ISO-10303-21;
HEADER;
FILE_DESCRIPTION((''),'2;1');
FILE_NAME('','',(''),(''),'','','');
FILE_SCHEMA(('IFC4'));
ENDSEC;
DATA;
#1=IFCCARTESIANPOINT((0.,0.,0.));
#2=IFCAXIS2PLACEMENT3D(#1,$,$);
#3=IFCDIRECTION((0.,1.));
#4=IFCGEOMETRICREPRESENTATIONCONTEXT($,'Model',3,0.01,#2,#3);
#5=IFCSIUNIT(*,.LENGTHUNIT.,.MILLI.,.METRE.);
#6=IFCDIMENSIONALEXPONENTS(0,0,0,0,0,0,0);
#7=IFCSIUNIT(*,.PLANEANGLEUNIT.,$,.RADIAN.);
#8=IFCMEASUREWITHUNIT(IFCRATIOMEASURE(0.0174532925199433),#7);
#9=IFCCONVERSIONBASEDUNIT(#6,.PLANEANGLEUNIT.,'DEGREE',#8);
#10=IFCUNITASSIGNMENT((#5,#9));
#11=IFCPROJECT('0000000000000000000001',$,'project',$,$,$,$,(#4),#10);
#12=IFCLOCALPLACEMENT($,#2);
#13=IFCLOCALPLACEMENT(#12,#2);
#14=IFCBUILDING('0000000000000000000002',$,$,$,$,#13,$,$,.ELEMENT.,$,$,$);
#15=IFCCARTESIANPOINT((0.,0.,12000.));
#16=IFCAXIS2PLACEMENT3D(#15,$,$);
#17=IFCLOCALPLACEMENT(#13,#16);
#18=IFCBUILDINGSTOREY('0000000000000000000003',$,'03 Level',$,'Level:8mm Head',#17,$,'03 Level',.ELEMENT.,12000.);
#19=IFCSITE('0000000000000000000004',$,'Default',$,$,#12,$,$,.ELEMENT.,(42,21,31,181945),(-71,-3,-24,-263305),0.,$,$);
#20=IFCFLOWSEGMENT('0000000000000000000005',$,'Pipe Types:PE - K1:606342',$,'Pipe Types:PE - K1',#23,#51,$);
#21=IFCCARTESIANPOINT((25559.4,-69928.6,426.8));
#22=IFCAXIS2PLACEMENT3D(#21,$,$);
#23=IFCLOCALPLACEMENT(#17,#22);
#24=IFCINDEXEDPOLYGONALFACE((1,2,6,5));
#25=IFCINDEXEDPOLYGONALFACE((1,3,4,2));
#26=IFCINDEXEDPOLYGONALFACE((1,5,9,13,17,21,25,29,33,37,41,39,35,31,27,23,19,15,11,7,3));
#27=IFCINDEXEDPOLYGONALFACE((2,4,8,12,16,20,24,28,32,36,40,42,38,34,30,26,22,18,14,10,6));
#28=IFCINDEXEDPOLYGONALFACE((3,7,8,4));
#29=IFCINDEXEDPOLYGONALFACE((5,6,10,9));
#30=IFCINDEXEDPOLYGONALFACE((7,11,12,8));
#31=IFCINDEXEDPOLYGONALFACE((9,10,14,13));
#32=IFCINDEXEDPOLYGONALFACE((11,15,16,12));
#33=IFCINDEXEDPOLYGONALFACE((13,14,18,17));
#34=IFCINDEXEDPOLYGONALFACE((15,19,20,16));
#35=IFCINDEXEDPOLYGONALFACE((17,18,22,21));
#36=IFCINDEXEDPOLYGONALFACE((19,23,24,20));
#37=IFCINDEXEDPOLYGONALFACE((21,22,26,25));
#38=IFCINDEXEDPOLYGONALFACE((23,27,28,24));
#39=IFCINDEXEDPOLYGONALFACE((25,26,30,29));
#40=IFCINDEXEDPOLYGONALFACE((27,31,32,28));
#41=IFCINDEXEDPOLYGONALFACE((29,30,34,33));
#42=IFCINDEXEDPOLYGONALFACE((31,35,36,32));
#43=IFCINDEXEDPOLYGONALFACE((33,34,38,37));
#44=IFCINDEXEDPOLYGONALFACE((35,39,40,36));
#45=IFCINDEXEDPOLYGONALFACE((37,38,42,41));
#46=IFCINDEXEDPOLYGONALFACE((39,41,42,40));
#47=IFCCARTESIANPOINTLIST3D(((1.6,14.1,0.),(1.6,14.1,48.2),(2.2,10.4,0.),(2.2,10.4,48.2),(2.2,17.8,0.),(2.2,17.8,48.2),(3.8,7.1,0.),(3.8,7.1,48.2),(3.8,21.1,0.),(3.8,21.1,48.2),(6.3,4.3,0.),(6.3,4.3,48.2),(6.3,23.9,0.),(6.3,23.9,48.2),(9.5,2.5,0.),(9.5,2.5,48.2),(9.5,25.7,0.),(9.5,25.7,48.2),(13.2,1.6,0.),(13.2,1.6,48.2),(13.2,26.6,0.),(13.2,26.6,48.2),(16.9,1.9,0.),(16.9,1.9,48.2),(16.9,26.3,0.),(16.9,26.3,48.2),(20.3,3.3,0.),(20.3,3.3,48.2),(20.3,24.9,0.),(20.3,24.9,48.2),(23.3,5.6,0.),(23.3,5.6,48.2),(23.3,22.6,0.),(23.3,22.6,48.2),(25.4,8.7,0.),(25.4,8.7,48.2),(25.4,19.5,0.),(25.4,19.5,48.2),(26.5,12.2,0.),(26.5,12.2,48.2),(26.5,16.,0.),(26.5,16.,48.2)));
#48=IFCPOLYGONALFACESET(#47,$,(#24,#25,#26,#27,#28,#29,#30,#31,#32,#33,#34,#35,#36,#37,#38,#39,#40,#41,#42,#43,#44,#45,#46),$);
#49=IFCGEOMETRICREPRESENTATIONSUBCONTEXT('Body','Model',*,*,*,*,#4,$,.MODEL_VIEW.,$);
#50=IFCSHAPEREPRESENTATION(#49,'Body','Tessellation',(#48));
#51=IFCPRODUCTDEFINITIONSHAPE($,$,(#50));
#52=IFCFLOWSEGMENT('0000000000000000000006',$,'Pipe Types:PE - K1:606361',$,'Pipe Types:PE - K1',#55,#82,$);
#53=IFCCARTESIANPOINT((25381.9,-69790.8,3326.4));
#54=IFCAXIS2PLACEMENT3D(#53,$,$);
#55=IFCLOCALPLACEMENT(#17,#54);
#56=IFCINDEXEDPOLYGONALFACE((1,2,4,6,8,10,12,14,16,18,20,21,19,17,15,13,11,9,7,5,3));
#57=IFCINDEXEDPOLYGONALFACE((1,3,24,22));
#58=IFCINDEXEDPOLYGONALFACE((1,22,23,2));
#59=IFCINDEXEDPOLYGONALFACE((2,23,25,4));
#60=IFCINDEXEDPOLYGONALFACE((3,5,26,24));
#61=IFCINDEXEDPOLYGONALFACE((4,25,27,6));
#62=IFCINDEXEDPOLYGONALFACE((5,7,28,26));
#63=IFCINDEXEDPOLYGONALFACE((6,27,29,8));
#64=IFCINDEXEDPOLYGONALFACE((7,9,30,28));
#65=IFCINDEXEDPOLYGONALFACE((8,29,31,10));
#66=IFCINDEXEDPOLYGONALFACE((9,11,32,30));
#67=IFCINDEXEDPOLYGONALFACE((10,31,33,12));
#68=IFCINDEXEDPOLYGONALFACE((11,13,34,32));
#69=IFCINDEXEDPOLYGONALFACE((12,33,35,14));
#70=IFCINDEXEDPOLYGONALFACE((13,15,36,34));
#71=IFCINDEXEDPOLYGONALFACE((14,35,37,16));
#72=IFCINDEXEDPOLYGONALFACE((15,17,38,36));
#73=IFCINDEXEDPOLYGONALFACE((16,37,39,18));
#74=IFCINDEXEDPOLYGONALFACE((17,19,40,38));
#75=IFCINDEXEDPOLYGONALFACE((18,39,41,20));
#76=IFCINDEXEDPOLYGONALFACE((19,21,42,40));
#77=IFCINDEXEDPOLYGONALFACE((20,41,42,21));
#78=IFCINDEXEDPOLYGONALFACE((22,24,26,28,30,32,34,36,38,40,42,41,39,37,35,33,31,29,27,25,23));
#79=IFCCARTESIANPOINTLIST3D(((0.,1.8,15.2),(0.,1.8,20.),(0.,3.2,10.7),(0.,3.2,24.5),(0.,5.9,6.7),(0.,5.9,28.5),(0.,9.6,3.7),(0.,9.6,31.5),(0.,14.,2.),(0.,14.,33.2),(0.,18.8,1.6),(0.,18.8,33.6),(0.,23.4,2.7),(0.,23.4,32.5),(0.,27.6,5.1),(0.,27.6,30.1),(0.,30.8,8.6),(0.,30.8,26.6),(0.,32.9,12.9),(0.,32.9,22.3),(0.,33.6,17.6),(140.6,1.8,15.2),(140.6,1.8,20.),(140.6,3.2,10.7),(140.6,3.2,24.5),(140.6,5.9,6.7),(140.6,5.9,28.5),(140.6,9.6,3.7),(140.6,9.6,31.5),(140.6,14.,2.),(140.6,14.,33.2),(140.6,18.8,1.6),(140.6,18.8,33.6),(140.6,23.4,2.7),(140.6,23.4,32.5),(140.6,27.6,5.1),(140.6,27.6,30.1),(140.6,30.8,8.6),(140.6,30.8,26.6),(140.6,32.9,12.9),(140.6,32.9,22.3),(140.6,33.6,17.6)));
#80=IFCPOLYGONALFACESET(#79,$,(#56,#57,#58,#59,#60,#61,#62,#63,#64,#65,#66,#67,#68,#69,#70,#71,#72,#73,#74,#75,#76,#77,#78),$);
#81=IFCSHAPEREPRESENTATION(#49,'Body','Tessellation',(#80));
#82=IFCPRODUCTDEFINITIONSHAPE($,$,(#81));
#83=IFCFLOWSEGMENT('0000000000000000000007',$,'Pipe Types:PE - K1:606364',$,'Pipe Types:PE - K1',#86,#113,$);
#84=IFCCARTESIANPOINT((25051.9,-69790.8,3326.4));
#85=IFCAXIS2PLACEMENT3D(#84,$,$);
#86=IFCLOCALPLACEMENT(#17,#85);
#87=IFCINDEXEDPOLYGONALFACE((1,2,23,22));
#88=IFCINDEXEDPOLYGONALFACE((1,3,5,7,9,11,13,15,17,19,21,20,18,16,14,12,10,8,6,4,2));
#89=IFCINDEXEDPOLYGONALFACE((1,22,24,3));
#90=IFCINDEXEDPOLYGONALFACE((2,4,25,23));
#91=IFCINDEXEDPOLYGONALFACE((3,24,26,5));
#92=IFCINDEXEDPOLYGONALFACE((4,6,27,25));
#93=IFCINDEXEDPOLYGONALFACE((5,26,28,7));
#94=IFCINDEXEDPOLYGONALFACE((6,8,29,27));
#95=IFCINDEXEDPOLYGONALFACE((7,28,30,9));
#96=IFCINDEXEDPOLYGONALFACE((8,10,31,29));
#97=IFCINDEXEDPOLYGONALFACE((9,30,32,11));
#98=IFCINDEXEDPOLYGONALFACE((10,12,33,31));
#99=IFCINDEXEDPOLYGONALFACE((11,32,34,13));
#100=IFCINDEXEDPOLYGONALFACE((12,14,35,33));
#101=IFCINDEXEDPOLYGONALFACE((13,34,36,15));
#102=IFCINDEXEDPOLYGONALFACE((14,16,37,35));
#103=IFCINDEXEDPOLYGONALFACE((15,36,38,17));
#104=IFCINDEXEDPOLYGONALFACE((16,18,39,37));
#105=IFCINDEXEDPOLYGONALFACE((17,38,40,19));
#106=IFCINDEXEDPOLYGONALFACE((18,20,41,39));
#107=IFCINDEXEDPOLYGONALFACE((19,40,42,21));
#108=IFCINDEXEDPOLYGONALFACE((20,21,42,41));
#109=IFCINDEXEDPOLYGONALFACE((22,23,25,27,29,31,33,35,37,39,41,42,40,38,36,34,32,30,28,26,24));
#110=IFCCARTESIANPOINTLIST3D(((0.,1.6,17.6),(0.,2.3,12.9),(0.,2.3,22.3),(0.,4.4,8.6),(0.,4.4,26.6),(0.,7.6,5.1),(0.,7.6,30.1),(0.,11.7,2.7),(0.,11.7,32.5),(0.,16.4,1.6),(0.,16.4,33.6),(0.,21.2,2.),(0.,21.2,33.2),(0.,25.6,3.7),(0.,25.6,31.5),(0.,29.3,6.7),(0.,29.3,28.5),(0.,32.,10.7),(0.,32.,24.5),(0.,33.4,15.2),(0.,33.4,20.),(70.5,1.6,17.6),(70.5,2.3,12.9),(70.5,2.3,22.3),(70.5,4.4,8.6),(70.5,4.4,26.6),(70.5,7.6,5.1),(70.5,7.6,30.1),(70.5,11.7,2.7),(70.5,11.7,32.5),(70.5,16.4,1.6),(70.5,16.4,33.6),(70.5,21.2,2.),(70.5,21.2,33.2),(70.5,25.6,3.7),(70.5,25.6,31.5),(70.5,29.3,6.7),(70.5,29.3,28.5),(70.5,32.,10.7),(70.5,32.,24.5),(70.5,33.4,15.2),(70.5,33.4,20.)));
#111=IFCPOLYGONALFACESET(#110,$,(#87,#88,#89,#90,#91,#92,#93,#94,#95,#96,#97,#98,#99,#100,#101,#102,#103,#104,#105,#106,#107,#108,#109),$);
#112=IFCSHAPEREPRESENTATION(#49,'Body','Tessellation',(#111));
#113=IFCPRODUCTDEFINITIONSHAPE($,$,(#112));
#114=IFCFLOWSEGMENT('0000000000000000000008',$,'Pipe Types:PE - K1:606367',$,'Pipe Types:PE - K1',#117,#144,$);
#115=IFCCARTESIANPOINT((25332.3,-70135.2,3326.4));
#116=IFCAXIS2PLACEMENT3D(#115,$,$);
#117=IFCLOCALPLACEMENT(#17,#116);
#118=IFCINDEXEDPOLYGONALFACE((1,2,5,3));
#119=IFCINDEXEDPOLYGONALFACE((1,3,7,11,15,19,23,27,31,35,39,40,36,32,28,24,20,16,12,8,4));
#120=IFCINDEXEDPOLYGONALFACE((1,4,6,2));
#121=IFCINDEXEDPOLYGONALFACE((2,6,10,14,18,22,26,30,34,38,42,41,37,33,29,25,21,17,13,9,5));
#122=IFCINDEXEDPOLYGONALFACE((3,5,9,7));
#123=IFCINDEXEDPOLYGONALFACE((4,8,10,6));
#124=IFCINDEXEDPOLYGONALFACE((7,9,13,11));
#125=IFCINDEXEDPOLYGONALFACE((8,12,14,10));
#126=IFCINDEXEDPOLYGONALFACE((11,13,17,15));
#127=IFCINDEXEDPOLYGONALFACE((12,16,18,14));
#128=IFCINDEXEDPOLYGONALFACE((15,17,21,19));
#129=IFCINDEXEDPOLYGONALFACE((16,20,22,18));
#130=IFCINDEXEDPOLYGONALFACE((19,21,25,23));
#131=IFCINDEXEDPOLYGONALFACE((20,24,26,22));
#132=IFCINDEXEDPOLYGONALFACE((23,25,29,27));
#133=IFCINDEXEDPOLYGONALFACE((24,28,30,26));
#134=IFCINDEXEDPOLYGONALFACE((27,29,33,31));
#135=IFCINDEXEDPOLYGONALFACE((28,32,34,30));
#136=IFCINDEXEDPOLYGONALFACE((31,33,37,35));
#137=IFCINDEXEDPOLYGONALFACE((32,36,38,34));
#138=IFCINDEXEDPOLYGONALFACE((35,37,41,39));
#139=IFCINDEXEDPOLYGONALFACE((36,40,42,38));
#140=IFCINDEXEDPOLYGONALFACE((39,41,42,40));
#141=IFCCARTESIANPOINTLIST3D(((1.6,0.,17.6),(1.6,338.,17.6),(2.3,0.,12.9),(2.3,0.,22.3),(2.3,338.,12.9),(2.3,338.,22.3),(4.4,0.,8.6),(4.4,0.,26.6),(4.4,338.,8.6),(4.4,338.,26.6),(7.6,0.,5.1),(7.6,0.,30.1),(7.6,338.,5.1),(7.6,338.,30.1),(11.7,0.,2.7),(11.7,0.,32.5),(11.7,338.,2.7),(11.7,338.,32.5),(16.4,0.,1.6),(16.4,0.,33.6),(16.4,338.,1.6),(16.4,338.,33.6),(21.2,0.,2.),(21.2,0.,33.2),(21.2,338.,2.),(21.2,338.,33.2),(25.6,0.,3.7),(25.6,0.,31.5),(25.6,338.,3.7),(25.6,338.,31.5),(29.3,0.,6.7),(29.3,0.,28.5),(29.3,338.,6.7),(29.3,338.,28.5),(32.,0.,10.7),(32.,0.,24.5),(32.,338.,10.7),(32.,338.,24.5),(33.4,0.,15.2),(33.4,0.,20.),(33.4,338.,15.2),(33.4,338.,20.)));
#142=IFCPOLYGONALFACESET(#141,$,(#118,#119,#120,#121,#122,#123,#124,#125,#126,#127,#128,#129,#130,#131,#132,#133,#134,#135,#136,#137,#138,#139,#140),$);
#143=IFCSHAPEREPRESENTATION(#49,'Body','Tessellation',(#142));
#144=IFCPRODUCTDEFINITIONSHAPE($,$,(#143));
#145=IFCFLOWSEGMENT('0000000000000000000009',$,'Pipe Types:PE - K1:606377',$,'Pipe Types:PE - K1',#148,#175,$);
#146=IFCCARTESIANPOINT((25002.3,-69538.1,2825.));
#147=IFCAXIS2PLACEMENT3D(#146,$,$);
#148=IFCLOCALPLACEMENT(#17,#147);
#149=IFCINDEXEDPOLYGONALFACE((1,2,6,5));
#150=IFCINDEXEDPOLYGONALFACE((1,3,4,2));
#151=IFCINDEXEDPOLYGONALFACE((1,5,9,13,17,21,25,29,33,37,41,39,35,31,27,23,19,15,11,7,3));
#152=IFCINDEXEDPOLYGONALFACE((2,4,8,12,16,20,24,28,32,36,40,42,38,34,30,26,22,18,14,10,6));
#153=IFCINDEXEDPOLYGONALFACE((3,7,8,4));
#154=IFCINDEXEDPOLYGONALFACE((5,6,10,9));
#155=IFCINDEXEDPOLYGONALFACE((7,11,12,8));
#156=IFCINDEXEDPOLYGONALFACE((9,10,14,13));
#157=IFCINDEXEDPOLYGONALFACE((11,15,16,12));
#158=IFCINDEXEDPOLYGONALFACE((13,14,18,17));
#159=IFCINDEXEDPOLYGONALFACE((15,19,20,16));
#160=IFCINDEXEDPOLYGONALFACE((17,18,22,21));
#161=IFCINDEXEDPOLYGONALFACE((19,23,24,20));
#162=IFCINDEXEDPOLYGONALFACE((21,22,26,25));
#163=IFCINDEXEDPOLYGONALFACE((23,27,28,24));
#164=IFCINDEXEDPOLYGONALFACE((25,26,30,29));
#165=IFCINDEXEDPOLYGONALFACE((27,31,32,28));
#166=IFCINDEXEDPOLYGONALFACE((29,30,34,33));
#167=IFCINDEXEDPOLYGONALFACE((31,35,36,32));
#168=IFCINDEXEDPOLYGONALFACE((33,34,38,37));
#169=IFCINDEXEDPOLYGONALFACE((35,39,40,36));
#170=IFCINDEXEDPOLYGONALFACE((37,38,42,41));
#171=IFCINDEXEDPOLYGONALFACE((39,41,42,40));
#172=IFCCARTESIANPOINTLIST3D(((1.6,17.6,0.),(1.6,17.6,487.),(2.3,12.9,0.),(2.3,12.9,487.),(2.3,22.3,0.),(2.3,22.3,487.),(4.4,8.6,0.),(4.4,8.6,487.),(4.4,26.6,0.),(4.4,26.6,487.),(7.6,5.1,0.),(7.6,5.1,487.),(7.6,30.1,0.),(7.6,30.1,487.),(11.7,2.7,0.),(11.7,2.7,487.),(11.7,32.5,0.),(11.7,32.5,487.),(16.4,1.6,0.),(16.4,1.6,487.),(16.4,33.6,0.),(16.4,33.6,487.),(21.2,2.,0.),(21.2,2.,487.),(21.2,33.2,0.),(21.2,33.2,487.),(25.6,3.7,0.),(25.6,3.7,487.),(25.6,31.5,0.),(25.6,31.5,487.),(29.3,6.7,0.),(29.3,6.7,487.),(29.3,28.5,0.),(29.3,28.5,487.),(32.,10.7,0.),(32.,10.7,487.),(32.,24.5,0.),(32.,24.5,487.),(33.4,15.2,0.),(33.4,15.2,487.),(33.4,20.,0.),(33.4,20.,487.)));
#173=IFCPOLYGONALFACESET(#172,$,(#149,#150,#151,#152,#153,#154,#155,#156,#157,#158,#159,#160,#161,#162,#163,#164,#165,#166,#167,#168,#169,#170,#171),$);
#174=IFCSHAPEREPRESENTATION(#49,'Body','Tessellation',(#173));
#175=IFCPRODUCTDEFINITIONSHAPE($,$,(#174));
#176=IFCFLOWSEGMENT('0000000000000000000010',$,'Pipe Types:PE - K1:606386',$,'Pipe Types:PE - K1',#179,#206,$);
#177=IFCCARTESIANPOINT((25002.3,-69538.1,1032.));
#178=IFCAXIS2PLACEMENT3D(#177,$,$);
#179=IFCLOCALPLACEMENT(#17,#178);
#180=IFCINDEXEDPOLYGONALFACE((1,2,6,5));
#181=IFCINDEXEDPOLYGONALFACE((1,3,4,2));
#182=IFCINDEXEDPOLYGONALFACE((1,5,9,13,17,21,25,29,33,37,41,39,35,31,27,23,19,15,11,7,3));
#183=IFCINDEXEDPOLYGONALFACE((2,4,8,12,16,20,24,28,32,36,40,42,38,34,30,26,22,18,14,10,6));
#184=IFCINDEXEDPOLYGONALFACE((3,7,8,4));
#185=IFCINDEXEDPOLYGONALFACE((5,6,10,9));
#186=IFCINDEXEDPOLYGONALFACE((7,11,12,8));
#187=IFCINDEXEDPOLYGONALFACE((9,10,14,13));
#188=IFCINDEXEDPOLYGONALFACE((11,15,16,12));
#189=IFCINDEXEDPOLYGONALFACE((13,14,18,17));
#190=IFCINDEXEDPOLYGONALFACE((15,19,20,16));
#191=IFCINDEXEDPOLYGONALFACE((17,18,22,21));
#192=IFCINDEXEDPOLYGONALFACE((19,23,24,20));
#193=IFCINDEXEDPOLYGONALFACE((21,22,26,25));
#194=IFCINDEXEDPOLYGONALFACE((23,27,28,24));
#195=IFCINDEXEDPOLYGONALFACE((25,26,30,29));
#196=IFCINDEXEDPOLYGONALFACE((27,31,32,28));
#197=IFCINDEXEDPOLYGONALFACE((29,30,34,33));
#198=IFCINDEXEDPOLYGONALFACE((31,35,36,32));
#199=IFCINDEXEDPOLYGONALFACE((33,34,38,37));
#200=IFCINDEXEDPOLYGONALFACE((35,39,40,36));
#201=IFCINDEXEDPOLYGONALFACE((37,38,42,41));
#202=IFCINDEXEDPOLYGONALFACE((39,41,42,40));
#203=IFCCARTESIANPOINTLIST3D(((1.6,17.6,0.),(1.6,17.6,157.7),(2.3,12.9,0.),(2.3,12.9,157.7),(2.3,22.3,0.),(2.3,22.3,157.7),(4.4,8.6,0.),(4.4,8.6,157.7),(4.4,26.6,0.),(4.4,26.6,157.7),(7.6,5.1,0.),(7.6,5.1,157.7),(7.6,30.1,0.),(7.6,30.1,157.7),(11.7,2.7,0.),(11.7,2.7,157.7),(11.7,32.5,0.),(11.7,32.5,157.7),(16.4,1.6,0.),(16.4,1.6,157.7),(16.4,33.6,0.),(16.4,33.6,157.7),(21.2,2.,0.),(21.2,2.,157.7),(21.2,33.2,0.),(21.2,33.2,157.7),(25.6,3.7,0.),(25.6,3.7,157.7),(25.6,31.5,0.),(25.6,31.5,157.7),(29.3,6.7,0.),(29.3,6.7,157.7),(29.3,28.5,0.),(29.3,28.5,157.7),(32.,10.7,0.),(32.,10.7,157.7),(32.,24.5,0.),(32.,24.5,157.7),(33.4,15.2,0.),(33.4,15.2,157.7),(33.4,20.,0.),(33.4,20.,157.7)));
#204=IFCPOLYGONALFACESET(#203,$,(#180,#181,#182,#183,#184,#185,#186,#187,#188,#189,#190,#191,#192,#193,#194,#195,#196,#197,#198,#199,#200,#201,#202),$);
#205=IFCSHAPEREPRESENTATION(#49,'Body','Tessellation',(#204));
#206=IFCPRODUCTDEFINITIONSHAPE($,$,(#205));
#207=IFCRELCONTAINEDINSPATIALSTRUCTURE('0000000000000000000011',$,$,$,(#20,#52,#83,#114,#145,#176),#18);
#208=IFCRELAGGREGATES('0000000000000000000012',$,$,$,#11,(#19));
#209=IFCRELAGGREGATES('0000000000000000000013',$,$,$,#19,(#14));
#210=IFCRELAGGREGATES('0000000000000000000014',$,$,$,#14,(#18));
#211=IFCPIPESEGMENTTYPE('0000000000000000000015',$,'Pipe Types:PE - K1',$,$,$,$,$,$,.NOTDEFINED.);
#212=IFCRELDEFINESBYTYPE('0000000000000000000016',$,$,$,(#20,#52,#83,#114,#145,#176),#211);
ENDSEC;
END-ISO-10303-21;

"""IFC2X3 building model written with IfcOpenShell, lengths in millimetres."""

from ifc_helpers import new_model, entity, si_unit, converted_unit, direction, frame, frame_2d, origin, origin_2d_with_axis, place, context, subcontext, project, spatial, circle, extrude, type_object, element, save


model = new_model("IFC2X3")

# Units and contexts
model_context = context("Model", 3, precision=0.01, world=origin(), true_north=direction((0.0, 1.0)))
body_context = subcontext(model_context, "Body", "Model", "MODEL_VIEW")
ifc_project = project(units=[si_unit("LENGTHUNIT", "METRE", prefix="MILLI"), converted_unit("PLANEANGLEUNIT", "DEGREE", entity("IfcRatioMeasure", 0.0174532925199433), si_unit("PLANEANGLEUNIT", "RADIAN"), dimensions=[0, 0, 0, 0, 0, 0, 0])], contexts=[model_context])

# Site, building, storey
site_placement = place(None, origin())
site = spatial("IfcSite", under=ifc_project, at=site_placement, Name="Default", CompositionType="ELEMENT", RefLatitude=(42, 21, 31, 181945), RefLongitude=(-71, -3, -24, -263305), RefElevation=0.0)
building_placement = place(site_placement, origin())
building = spatial("IfcBuilding", under=site, at=building_placement, CompositionType="ELEMENT")
storey_placement = place(building_placement, frame((0.0, 0.0, 12000.0)))
storey = spatial("IfcBuildingStorey", under=building, at=storey_placement, Name="03 Level", ObjectType="Level:8mm Head", LongName="03 Level", CompositionType="ELEMENT", Elevation=12000.0)

# Flow segments
pipe_segment_type = type_object("IfcPipeSegmentType", Name="Pipe Types:PE - K1", PredefinedType="NOTDEFINED")
flow_segment_1_placement = place(storey_placement, frame((25559.4, -69928.6, 426.8)))
element("IfcFlowSegment", 1, at=flow_segment_1_placement, inside=storey, type_object=pipe_segment_type, Name="Pipe Types:PE - K1:606342", ObjectType="Pipe Types:PE - K1", context=body_context, shape_type="SweptSolid", body=[
    extrude(circle(Radius=12.5, at=frame_2d((0.0, 0.0), x_axis=(1.0, 0.0))), frame((14.1, 14.1, 0.0), z_axis=(0.0, 0.0, 1.0), x_axis=(-1.0, 0.0, 0.0)), (0.0, 0.0, 1.0), 48.2),
])
flow_segment_2_placement = place(storey_placement, frame((25381.9, -69790.8, 3326.4)))
element("IfcFlowSegment", 2, at=flow_segment_2_placement, inside=storey, type_object=pipe_segment_type, Name="Pipe Types:PE - K1:606361", ObjectType="Pipe Types:PE - K1", context=body_context, shape_type="SweptSolid", body=[
    extrude(circle(Radius=16.0, at=frame_2d((0.0, 0.0), x_axis=(1.0, 0.0))), frame((0.0, 17.6, 17.6), z_axis=(1.0, 0.0, 0.0), x_axis=(0.0, 1.0, 0.0)), (0.0, 0.0, 1.0), 140.6),
])
flow_segment_3_placement = place(storey_placement, frame((25051.9, -69790.8, 3326.4)))
element("IfcFlowSegment", 3, at=flow_segment_3_placement, inside=storey, type_object=pipe_segment_type, Name="Pipe Types:PE - K1:606364", ObjectType="Pipe Types:PE - K1", context=body_context, shape_type="SweptSolid", body=[
    extrude(circle(Radius=16.0, at=origin_2d_with_axis()), frame((0.0, 17.6, 17.6), z_axis=(1.0, 0.0, 0.0), x_axis=(0.0, -1.0, 0.0)), (0.0, 0.0, 1.0), 70.5),
])
flow_segment_4_placement = place(storey_placement, frame((25332.3, -70135.2, 3326.4)))
element("IfcFlowSegment", 4, at=flow_segment_4_placement, inside=storey, type_object=pipe_segment_type, Name="Pipe Types:PE - K1:606367", ObjectType="Pipe Types:PE - K1", context=body_context, shape_type="SweptSolid", body=[
    extrude(circle(Radius=16.0, at=origin_2d_with_axis()), frame((17.6, 0.0, 17.6), z_axis=(0.0, 1.0, 0.0), x_axis=(-1.0, 0.0, 0.0)), (0.0, 0.0, 1.0), 338.0),
])
flow_segment_5_placement = place(storey_placement, frame((25002.3, -69538.1, 2825.0)))
element("IfcFlowSegment", 5, at=flow_segment_5_placement, inside=storey, type_object=pipe_segment_type, Name="Pipe Types:PE - K1:606377", ObjectType="Pipe Types:PE - K1", context=body_context, shape_type="SweptSolid", body=[
    extrude(circle(Radius=16.0, at=origin_2d_with_axis()), frame((17.6, 17.6, 0.0), z_axis=(0.0, 0.0, 1.0), x_axis=(-1.0, 0.0, 0.0)), (0.0, 0.0, 1.0), 487.0),
])
flow_segment_6_placement = place(storey_placement, frame((25002.3, -69538.1, 1032.0)))
element("IfcFlowSegment", 6, at=flow_segment_6_placement, inside=storey, type_object=pipe_segment_type, Name="Pipe Types:PE - K1:606386", ObjectType="Pipe Types:PE - K1", context=body_context, shape_type="SweptSolid", body=[
    extrude(circle(Radius=16.0, at=origin_2d_with_axis()), frame((17.6, 17.6, 0.0), z_axis=(0.0, 0.0, 1.0), x_axis=(-1.0, 0.0, 0.0)), (0.0, 0.0, 1.0), 157.7),
])

save(model, "model.ifc")
